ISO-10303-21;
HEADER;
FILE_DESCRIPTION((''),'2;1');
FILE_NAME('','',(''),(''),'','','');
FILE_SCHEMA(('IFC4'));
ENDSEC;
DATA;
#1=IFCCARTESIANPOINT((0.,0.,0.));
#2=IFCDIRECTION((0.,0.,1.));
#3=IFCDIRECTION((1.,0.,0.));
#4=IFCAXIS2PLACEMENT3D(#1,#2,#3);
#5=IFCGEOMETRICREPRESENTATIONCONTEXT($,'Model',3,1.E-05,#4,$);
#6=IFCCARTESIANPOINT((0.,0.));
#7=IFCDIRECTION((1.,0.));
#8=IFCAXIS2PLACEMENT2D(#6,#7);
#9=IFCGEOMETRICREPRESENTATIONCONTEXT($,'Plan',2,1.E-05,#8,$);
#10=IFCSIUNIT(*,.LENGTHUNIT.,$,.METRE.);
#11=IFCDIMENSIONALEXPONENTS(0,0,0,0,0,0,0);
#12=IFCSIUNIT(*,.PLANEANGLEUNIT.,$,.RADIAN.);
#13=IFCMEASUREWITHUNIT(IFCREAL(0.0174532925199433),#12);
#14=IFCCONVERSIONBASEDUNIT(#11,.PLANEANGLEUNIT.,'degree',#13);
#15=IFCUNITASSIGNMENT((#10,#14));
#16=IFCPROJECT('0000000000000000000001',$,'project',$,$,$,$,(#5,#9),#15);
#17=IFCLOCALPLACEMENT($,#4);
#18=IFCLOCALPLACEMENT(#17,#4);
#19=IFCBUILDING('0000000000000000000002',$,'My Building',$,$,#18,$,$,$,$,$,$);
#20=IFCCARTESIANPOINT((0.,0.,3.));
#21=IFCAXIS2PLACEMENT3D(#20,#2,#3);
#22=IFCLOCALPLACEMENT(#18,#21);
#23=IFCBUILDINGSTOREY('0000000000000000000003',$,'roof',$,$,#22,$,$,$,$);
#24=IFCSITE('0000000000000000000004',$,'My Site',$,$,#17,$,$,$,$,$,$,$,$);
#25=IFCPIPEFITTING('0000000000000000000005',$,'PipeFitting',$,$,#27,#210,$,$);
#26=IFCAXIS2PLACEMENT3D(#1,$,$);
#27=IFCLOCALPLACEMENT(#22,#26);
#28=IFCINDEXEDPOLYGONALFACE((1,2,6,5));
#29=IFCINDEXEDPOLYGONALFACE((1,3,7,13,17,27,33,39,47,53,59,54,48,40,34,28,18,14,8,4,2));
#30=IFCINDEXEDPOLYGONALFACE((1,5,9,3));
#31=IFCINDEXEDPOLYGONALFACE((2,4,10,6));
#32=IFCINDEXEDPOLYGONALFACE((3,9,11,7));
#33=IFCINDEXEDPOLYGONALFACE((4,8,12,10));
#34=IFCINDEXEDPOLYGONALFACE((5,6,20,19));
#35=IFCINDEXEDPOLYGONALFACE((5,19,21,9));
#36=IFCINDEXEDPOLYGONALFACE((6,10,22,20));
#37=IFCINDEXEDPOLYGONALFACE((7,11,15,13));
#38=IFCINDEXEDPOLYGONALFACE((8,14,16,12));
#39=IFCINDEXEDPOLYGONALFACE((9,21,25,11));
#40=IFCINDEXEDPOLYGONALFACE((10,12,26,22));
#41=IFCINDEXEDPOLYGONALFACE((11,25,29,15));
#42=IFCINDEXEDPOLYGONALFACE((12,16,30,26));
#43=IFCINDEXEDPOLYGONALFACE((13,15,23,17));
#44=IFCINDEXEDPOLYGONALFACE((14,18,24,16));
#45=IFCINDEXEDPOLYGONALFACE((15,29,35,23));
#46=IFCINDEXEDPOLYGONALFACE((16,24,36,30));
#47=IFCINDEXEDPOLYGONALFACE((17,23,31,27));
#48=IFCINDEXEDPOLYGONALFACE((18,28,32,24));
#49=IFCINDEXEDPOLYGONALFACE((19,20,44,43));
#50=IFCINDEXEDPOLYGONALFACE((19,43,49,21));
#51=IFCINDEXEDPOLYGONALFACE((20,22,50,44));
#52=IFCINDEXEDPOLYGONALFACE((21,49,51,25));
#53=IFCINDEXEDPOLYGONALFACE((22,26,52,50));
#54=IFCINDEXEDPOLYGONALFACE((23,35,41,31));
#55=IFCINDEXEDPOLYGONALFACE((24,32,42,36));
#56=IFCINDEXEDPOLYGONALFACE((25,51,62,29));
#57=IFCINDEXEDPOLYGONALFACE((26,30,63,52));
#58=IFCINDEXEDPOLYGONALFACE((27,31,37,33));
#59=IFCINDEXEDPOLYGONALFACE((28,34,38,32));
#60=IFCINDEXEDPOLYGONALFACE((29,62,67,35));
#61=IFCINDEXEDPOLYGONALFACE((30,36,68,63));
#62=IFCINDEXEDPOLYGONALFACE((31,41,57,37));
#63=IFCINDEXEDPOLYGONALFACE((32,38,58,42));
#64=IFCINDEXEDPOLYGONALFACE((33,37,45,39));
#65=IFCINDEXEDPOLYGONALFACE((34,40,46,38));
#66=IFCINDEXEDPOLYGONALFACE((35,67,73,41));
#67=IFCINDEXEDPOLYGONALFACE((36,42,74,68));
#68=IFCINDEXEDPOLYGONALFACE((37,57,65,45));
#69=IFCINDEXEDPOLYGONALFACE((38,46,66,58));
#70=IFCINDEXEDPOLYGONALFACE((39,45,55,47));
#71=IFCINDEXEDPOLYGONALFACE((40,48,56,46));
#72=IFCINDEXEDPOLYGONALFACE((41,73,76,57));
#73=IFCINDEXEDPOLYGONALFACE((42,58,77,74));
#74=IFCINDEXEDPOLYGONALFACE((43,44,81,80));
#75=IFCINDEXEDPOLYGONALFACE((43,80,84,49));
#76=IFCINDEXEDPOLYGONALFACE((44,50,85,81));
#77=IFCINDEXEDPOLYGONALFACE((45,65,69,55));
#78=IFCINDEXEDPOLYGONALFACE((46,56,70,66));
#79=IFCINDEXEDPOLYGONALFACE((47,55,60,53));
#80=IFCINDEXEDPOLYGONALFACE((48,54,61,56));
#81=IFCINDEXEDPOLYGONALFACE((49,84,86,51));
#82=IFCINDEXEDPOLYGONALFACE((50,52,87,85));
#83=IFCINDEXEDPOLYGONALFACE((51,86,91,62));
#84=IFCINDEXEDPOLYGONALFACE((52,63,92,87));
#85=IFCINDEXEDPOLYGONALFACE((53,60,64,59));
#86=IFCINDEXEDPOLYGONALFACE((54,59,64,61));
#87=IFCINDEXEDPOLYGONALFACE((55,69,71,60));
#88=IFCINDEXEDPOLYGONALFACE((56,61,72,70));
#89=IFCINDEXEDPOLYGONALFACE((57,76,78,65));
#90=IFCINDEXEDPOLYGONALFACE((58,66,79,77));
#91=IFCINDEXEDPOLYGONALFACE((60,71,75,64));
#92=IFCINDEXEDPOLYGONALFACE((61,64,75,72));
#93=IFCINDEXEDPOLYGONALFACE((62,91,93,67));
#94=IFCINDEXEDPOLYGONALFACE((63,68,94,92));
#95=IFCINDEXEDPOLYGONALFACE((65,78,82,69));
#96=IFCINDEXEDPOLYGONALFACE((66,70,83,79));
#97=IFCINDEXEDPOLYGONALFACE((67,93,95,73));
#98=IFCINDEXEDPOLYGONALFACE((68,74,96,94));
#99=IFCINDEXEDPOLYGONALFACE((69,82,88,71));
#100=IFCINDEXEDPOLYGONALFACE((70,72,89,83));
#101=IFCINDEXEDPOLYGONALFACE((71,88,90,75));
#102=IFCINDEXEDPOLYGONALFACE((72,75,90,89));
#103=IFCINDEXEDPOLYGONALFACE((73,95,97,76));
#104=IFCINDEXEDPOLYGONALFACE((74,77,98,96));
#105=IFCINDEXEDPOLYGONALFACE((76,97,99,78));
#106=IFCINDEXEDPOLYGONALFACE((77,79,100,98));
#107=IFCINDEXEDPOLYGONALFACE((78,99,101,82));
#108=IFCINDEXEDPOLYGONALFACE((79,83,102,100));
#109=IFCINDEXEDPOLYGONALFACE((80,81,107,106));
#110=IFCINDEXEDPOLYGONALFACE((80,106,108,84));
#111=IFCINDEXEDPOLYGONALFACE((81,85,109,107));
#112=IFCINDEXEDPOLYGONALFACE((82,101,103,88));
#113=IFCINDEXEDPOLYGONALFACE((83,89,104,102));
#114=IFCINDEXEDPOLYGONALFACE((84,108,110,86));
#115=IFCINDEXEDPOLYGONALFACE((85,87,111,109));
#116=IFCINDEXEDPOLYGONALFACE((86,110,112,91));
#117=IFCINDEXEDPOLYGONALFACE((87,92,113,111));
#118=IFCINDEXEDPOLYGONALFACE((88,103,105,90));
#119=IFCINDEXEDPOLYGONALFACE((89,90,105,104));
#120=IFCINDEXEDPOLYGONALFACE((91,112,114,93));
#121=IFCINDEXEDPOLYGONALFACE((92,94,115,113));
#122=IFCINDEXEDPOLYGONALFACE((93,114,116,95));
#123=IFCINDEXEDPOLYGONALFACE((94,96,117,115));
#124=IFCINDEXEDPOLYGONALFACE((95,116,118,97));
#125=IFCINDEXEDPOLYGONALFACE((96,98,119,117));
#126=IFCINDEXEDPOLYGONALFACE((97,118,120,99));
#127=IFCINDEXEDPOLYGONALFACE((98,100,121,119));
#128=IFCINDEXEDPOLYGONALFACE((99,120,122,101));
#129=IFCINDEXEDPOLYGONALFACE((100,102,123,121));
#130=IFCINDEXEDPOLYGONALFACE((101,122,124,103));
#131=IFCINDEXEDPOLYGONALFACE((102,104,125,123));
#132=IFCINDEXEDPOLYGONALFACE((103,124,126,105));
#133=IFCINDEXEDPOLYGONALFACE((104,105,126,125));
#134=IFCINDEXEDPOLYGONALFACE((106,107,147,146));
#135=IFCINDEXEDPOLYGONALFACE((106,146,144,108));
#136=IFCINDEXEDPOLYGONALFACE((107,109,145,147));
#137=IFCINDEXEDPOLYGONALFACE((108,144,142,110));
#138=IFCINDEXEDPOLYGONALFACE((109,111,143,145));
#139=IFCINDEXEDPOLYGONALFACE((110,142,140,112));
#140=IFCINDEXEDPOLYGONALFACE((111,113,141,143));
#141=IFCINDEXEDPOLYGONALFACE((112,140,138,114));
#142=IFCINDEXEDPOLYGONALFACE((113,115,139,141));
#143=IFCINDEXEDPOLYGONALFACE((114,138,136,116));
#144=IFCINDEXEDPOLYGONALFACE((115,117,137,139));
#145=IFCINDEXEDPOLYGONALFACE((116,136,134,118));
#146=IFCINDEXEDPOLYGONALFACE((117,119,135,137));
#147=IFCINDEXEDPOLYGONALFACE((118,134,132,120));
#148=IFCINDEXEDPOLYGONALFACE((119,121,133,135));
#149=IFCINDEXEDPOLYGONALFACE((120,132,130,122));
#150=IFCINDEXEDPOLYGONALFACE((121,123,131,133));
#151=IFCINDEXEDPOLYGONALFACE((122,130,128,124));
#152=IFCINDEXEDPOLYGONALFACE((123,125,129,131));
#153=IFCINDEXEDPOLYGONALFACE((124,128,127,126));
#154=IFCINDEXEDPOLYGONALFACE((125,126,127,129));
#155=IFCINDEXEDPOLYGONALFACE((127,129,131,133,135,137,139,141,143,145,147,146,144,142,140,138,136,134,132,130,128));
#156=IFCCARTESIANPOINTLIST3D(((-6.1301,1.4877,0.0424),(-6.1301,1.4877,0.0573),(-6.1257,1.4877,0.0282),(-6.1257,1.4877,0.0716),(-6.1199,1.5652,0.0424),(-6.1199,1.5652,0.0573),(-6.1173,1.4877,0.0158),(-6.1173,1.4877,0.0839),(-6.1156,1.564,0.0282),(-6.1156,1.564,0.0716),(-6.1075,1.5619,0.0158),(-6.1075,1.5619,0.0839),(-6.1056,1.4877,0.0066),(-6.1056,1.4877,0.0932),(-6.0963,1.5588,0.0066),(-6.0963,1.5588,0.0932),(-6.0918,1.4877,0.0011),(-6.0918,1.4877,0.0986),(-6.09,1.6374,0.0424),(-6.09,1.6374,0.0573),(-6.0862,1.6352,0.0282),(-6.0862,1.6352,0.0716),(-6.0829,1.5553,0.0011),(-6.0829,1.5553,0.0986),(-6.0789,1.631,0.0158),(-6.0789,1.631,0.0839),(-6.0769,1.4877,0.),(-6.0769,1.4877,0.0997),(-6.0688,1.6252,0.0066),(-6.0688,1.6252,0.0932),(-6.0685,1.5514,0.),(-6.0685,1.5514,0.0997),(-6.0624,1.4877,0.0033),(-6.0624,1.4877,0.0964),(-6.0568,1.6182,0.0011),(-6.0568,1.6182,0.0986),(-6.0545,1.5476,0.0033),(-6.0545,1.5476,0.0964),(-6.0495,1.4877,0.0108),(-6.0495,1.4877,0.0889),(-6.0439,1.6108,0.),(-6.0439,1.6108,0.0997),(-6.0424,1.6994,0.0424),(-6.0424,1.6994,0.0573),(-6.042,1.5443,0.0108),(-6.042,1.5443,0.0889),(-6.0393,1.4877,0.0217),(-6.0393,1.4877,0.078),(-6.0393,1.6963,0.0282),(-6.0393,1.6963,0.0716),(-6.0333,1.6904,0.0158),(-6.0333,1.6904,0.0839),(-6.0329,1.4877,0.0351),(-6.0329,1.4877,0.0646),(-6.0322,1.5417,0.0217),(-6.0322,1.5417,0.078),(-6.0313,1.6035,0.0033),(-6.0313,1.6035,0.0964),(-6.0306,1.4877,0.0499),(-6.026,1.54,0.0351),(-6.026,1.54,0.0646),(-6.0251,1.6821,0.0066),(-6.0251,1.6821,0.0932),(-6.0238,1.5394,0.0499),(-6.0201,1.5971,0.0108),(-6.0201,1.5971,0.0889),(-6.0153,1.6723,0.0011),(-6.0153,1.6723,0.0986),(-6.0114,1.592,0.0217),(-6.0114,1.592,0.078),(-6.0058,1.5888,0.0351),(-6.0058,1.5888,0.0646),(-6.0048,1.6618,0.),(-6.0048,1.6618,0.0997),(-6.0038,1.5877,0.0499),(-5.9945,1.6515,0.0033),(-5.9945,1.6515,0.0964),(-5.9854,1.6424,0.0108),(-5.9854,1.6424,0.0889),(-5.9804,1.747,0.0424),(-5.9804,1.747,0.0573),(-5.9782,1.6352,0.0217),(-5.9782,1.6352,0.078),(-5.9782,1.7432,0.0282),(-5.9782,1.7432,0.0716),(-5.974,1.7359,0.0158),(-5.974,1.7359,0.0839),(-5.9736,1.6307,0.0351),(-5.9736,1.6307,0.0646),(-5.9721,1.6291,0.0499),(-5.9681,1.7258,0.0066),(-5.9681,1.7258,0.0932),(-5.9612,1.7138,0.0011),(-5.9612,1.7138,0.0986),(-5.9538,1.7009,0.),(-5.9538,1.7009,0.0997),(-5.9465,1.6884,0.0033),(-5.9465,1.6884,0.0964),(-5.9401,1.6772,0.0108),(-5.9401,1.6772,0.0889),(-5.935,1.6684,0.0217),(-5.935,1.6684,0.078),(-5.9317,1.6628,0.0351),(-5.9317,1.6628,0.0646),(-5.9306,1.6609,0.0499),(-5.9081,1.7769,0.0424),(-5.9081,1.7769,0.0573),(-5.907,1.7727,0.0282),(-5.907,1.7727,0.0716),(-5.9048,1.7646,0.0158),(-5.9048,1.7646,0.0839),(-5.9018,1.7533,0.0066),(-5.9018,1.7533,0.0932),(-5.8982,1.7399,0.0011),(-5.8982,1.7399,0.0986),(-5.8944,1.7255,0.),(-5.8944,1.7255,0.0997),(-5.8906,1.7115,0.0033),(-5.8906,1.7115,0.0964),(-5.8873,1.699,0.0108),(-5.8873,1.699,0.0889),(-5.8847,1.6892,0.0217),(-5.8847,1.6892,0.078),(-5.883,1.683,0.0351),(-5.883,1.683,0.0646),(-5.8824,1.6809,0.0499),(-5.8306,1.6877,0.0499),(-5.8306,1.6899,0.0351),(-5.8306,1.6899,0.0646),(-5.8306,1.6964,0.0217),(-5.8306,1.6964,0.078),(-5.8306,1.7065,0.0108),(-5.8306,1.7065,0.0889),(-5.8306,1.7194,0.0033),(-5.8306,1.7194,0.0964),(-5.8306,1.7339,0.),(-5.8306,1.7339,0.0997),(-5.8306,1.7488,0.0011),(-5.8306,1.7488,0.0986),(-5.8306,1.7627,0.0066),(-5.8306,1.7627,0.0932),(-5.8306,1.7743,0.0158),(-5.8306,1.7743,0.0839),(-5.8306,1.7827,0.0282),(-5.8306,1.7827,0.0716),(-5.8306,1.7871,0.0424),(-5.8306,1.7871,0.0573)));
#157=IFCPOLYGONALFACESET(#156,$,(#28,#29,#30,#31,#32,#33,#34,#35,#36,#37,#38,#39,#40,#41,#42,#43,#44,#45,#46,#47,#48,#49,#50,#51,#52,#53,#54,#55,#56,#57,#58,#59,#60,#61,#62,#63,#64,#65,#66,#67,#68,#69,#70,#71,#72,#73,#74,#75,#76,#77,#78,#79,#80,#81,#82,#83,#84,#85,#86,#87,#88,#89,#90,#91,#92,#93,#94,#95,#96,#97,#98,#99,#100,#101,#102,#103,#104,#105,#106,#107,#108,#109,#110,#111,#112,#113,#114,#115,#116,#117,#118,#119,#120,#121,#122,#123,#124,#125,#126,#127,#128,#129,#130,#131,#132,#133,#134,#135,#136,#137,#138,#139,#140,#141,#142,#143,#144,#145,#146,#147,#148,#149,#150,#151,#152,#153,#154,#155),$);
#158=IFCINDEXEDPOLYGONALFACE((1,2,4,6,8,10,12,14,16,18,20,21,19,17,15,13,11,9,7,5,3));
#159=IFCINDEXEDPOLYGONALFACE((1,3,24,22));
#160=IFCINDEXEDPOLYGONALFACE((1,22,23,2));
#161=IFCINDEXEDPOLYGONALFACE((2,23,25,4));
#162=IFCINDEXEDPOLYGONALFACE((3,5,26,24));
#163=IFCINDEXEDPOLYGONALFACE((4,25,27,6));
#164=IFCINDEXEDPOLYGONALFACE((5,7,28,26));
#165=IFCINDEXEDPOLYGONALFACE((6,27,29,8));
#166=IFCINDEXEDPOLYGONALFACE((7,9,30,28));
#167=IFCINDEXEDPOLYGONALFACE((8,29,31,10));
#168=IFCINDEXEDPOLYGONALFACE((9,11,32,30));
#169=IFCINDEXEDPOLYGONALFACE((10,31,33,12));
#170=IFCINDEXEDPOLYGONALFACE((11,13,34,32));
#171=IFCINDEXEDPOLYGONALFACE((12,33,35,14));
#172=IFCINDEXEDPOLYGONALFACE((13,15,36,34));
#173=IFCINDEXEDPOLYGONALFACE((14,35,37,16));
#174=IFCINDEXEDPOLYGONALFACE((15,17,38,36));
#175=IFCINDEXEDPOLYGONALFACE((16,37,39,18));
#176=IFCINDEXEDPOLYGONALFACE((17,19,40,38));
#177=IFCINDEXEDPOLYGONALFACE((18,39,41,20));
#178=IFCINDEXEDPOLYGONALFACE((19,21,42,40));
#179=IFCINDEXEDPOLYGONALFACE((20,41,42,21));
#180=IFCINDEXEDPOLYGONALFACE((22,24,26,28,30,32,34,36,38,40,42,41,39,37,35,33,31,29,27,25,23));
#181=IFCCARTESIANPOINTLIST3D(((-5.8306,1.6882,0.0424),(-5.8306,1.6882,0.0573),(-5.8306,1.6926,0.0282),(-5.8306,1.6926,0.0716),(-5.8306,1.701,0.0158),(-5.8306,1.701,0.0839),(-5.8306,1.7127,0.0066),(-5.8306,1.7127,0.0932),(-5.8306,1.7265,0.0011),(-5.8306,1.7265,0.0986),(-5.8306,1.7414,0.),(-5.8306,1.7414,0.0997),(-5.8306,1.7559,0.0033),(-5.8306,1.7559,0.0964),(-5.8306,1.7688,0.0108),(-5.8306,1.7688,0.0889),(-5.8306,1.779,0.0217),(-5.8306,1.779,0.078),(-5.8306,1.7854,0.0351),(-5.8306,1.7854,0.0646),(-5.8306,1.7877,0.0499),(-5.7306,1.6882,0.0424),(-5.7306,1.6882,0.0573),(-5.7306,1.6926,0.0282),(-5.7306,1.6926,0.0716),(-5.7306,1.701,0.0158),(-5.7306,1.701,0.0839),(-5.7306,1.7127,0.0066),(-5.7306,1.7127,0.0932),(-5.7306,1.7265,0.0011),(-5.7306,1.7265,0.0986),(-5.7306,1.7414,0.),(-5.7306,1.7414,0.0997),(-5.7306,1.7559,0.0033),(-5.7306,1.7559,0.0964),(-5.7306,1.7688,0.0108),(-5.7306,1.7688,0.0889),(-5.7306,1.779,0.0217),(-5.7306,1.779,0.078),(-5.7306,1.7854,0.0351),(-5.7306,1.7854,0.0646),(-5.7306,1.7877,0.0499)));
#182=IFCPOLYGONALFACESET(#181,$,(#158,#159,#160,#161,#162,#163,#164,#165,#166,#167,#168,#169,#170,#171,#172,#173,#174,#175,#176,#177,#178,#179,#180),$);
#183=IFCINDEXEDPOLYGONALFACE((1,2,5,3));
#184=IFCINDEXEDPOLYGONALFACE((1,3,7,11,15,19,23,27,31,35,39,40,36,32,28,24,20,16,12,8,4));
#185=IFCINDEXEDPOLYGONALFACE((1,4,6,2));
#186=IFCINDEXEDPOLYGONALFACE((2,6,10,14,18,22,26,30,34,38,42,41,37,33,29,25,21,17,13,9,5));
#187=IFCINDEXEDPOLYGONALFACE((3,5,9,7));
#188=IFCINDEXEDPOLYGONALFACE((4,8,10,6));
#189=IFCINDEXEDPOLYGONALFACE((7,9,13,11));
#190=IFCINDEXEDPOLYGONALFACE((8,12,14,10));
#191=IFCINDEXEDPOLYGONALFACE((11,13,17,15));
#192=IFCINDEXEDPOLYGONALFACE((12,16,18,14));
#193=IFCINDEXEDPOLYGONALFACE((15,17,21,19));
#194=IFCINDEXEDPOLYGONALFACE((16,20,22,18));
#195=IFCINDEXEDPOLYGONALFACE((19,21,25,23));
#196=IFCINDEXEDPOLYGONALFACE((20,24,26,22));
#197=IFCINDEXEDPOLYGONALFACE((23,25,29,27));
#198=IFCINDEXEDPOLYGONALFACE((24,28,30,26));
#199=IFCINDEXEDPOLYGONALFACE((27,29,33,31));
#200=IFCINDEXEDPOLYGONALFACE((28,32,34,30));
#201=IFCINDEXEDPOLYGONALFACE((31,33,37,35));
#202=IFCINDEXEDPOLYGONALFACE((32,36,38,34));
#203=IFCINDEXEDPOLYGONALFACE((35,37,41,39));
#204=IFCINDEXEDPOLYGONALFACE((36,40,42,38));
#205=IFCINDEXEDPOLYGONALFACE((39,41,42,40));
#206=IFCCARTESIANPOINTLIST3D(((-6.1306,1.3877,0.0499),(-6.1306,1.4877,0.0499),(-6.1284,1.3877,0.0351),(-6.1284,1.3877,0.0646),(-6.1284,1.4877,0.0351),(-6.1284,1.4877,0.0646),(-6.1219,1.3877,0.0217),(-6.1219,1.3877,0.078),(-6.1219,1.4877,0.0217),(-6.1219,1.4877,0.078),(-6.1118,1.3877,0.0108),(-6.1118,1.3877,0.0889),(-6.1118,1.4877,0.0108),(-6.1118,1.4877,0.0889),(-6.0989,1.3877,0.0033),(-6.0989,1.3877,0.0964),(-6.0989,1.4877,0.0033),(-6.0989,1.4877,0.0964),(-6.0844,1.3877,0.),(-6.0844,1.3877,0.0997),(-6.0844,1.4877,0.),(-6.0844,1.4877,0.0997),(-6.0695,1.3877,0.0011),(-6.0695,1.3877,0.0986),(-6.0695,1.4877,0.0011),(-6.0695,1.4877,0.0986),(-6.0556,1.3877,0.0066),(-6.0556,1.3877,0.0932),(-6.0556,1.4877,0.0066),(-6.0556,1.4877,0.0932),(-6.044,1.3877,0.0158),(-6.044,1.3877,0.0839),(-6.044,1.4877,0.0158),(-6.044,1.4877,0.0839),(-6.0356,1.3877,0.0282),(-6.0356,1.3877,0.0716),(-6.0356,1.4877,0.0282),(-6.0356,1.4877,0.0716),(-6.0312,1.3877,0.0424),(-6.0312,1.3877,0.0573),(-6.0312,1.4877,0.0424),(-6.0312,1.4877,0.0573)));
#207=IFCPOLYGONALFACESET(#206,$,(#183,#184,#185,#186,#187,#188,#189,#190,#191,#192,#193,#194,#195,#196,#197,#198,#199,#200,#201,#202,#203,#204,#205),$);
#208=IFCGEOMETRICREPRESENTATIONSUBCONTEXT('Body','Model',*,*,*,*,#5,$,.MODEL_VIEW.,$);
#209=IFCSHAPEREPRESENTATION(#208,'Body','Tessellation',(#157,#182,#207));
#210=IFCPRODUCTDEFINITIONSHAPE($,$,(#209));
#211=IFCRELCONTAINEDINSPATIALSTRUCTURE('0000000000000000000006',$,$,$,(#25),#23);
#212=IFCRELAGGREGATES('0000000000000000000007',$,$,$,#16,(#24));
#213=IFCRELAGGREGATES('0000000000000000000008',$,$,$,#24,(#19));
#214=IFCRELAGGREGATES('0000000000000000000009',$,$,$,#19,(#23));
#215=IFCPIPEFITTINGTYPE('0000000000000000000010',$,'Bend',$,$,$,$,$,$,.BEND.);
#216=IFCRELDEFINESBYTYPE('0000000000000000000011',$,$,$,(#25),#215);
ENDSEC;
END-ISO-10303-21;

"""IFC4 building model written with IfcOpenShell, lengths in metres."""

from ifc_helpers import new_model, entity, si_unit, converted_unit, frame, origin_with_axes, origin_2d_with_axis, place, context, subcontext, project, spatial, circle, extrude, source, transform, mapped, type_object, type_shapes, element, save


model = new_model("IFC4")

# Units and contexts
model_context = context("Model", 3, precision=1e-05, world=origin_with_axes())
plan_context = context("Plan", 2, precision=1e-05, world=origin_2d_with_axis())
body_context = subcontext(model_context, "Body", "Model", "MODEL_VIEW")
ifc_project = project(units=[si_unit("LENGTHUNIT", "METRE"), converted_unit("PLANEANGLEUNIT", "degree", entity("IfcReal", 0.0174532925199433), si_unit("PLANEANGLEUNIT", "RADIAN"), dimensions=[0, 0, 0, 0, 0, 0, 0])], contexts=[model_context, plan_context])

# Site, building, storey
site_placement = place(None, origin_with_axes())
site = spatial("IfcSite", under=ifc_project, at=site_placement, Name="My Site")
building_placement = place(site_placement, origin_with_axes())
building = spatial("IfcBuilding", under=site, at=building_placement, Name="My Building")
storey_placement = place(building_placement, frame((0.0, 0.0, 3.0), z_axis=(0.0, 0.0, 1.0), x_axis=(1.0, 0.0, 0.0)))
storey = spatial("IfcBuildingStorey", under=building, at=storey_placement, Name="roof")

# Pipe fitting
pipe_fitting_type_1 = type_object("IfcPipeFittingType", Name="Bend", PredefinedType="BEND")
shared_shape_1 = source(origin_with_axes(), body_context, "Body", "SolidModel", [
    entity("IfcSweptDiskSolid", entity("IfcIndexedPolyCurve", entity("IfcCartesianPointList3D", [[0.0, 0.0, -0.1], [-0.0732, 0.0, -0.2768], [-0.25, 0.0, -0.35]]), [entity("IfcArcIndex", [1, 2, 3])]), 0.05),
    extrude(circle(Radius=0.05), origin_with_axes(), (0.0, 0.0, -1.0), 0.1),
    extrude(circle(Radius=0.05), frame((-0.25, 0.0, -0.35), z_axis=(-1.0, 0.0, 0.0), x_axis=(0.0, 0.0, -1.0)), (0.0, 0.0, 1.0), 0.1),
])
type_shapes(pipe_fitting_type_1, [shared_shape_1])
for number, where, z_axis, x_axis, name in (
    (1, (-5.7306, 1.7377, 0.0499), (1.0, 0.0, 0.0), (0.0, 1.0, 0.0), "PipeFitting"),
):
    element("IfcPipeFitting", number, at=place(storey_placement, frame(where, z_axis=z_axis, x_axis=x_axis)), inside=storey, type_object=pipe_fitting_type_1, Name=name, context=body_context, shape_type="MappedRepresentation", body=[
        mapped(shared_shape_1, transform((0.0, 0.0, 0.0), x_axis=(1.0, 0.0, 0.0), y_axis=(0.0, 1.0, 0.0), z_axis=(0.0, 0.0, 1.0), scale=1.0)),
    ])

save(model, "model.ifc")
